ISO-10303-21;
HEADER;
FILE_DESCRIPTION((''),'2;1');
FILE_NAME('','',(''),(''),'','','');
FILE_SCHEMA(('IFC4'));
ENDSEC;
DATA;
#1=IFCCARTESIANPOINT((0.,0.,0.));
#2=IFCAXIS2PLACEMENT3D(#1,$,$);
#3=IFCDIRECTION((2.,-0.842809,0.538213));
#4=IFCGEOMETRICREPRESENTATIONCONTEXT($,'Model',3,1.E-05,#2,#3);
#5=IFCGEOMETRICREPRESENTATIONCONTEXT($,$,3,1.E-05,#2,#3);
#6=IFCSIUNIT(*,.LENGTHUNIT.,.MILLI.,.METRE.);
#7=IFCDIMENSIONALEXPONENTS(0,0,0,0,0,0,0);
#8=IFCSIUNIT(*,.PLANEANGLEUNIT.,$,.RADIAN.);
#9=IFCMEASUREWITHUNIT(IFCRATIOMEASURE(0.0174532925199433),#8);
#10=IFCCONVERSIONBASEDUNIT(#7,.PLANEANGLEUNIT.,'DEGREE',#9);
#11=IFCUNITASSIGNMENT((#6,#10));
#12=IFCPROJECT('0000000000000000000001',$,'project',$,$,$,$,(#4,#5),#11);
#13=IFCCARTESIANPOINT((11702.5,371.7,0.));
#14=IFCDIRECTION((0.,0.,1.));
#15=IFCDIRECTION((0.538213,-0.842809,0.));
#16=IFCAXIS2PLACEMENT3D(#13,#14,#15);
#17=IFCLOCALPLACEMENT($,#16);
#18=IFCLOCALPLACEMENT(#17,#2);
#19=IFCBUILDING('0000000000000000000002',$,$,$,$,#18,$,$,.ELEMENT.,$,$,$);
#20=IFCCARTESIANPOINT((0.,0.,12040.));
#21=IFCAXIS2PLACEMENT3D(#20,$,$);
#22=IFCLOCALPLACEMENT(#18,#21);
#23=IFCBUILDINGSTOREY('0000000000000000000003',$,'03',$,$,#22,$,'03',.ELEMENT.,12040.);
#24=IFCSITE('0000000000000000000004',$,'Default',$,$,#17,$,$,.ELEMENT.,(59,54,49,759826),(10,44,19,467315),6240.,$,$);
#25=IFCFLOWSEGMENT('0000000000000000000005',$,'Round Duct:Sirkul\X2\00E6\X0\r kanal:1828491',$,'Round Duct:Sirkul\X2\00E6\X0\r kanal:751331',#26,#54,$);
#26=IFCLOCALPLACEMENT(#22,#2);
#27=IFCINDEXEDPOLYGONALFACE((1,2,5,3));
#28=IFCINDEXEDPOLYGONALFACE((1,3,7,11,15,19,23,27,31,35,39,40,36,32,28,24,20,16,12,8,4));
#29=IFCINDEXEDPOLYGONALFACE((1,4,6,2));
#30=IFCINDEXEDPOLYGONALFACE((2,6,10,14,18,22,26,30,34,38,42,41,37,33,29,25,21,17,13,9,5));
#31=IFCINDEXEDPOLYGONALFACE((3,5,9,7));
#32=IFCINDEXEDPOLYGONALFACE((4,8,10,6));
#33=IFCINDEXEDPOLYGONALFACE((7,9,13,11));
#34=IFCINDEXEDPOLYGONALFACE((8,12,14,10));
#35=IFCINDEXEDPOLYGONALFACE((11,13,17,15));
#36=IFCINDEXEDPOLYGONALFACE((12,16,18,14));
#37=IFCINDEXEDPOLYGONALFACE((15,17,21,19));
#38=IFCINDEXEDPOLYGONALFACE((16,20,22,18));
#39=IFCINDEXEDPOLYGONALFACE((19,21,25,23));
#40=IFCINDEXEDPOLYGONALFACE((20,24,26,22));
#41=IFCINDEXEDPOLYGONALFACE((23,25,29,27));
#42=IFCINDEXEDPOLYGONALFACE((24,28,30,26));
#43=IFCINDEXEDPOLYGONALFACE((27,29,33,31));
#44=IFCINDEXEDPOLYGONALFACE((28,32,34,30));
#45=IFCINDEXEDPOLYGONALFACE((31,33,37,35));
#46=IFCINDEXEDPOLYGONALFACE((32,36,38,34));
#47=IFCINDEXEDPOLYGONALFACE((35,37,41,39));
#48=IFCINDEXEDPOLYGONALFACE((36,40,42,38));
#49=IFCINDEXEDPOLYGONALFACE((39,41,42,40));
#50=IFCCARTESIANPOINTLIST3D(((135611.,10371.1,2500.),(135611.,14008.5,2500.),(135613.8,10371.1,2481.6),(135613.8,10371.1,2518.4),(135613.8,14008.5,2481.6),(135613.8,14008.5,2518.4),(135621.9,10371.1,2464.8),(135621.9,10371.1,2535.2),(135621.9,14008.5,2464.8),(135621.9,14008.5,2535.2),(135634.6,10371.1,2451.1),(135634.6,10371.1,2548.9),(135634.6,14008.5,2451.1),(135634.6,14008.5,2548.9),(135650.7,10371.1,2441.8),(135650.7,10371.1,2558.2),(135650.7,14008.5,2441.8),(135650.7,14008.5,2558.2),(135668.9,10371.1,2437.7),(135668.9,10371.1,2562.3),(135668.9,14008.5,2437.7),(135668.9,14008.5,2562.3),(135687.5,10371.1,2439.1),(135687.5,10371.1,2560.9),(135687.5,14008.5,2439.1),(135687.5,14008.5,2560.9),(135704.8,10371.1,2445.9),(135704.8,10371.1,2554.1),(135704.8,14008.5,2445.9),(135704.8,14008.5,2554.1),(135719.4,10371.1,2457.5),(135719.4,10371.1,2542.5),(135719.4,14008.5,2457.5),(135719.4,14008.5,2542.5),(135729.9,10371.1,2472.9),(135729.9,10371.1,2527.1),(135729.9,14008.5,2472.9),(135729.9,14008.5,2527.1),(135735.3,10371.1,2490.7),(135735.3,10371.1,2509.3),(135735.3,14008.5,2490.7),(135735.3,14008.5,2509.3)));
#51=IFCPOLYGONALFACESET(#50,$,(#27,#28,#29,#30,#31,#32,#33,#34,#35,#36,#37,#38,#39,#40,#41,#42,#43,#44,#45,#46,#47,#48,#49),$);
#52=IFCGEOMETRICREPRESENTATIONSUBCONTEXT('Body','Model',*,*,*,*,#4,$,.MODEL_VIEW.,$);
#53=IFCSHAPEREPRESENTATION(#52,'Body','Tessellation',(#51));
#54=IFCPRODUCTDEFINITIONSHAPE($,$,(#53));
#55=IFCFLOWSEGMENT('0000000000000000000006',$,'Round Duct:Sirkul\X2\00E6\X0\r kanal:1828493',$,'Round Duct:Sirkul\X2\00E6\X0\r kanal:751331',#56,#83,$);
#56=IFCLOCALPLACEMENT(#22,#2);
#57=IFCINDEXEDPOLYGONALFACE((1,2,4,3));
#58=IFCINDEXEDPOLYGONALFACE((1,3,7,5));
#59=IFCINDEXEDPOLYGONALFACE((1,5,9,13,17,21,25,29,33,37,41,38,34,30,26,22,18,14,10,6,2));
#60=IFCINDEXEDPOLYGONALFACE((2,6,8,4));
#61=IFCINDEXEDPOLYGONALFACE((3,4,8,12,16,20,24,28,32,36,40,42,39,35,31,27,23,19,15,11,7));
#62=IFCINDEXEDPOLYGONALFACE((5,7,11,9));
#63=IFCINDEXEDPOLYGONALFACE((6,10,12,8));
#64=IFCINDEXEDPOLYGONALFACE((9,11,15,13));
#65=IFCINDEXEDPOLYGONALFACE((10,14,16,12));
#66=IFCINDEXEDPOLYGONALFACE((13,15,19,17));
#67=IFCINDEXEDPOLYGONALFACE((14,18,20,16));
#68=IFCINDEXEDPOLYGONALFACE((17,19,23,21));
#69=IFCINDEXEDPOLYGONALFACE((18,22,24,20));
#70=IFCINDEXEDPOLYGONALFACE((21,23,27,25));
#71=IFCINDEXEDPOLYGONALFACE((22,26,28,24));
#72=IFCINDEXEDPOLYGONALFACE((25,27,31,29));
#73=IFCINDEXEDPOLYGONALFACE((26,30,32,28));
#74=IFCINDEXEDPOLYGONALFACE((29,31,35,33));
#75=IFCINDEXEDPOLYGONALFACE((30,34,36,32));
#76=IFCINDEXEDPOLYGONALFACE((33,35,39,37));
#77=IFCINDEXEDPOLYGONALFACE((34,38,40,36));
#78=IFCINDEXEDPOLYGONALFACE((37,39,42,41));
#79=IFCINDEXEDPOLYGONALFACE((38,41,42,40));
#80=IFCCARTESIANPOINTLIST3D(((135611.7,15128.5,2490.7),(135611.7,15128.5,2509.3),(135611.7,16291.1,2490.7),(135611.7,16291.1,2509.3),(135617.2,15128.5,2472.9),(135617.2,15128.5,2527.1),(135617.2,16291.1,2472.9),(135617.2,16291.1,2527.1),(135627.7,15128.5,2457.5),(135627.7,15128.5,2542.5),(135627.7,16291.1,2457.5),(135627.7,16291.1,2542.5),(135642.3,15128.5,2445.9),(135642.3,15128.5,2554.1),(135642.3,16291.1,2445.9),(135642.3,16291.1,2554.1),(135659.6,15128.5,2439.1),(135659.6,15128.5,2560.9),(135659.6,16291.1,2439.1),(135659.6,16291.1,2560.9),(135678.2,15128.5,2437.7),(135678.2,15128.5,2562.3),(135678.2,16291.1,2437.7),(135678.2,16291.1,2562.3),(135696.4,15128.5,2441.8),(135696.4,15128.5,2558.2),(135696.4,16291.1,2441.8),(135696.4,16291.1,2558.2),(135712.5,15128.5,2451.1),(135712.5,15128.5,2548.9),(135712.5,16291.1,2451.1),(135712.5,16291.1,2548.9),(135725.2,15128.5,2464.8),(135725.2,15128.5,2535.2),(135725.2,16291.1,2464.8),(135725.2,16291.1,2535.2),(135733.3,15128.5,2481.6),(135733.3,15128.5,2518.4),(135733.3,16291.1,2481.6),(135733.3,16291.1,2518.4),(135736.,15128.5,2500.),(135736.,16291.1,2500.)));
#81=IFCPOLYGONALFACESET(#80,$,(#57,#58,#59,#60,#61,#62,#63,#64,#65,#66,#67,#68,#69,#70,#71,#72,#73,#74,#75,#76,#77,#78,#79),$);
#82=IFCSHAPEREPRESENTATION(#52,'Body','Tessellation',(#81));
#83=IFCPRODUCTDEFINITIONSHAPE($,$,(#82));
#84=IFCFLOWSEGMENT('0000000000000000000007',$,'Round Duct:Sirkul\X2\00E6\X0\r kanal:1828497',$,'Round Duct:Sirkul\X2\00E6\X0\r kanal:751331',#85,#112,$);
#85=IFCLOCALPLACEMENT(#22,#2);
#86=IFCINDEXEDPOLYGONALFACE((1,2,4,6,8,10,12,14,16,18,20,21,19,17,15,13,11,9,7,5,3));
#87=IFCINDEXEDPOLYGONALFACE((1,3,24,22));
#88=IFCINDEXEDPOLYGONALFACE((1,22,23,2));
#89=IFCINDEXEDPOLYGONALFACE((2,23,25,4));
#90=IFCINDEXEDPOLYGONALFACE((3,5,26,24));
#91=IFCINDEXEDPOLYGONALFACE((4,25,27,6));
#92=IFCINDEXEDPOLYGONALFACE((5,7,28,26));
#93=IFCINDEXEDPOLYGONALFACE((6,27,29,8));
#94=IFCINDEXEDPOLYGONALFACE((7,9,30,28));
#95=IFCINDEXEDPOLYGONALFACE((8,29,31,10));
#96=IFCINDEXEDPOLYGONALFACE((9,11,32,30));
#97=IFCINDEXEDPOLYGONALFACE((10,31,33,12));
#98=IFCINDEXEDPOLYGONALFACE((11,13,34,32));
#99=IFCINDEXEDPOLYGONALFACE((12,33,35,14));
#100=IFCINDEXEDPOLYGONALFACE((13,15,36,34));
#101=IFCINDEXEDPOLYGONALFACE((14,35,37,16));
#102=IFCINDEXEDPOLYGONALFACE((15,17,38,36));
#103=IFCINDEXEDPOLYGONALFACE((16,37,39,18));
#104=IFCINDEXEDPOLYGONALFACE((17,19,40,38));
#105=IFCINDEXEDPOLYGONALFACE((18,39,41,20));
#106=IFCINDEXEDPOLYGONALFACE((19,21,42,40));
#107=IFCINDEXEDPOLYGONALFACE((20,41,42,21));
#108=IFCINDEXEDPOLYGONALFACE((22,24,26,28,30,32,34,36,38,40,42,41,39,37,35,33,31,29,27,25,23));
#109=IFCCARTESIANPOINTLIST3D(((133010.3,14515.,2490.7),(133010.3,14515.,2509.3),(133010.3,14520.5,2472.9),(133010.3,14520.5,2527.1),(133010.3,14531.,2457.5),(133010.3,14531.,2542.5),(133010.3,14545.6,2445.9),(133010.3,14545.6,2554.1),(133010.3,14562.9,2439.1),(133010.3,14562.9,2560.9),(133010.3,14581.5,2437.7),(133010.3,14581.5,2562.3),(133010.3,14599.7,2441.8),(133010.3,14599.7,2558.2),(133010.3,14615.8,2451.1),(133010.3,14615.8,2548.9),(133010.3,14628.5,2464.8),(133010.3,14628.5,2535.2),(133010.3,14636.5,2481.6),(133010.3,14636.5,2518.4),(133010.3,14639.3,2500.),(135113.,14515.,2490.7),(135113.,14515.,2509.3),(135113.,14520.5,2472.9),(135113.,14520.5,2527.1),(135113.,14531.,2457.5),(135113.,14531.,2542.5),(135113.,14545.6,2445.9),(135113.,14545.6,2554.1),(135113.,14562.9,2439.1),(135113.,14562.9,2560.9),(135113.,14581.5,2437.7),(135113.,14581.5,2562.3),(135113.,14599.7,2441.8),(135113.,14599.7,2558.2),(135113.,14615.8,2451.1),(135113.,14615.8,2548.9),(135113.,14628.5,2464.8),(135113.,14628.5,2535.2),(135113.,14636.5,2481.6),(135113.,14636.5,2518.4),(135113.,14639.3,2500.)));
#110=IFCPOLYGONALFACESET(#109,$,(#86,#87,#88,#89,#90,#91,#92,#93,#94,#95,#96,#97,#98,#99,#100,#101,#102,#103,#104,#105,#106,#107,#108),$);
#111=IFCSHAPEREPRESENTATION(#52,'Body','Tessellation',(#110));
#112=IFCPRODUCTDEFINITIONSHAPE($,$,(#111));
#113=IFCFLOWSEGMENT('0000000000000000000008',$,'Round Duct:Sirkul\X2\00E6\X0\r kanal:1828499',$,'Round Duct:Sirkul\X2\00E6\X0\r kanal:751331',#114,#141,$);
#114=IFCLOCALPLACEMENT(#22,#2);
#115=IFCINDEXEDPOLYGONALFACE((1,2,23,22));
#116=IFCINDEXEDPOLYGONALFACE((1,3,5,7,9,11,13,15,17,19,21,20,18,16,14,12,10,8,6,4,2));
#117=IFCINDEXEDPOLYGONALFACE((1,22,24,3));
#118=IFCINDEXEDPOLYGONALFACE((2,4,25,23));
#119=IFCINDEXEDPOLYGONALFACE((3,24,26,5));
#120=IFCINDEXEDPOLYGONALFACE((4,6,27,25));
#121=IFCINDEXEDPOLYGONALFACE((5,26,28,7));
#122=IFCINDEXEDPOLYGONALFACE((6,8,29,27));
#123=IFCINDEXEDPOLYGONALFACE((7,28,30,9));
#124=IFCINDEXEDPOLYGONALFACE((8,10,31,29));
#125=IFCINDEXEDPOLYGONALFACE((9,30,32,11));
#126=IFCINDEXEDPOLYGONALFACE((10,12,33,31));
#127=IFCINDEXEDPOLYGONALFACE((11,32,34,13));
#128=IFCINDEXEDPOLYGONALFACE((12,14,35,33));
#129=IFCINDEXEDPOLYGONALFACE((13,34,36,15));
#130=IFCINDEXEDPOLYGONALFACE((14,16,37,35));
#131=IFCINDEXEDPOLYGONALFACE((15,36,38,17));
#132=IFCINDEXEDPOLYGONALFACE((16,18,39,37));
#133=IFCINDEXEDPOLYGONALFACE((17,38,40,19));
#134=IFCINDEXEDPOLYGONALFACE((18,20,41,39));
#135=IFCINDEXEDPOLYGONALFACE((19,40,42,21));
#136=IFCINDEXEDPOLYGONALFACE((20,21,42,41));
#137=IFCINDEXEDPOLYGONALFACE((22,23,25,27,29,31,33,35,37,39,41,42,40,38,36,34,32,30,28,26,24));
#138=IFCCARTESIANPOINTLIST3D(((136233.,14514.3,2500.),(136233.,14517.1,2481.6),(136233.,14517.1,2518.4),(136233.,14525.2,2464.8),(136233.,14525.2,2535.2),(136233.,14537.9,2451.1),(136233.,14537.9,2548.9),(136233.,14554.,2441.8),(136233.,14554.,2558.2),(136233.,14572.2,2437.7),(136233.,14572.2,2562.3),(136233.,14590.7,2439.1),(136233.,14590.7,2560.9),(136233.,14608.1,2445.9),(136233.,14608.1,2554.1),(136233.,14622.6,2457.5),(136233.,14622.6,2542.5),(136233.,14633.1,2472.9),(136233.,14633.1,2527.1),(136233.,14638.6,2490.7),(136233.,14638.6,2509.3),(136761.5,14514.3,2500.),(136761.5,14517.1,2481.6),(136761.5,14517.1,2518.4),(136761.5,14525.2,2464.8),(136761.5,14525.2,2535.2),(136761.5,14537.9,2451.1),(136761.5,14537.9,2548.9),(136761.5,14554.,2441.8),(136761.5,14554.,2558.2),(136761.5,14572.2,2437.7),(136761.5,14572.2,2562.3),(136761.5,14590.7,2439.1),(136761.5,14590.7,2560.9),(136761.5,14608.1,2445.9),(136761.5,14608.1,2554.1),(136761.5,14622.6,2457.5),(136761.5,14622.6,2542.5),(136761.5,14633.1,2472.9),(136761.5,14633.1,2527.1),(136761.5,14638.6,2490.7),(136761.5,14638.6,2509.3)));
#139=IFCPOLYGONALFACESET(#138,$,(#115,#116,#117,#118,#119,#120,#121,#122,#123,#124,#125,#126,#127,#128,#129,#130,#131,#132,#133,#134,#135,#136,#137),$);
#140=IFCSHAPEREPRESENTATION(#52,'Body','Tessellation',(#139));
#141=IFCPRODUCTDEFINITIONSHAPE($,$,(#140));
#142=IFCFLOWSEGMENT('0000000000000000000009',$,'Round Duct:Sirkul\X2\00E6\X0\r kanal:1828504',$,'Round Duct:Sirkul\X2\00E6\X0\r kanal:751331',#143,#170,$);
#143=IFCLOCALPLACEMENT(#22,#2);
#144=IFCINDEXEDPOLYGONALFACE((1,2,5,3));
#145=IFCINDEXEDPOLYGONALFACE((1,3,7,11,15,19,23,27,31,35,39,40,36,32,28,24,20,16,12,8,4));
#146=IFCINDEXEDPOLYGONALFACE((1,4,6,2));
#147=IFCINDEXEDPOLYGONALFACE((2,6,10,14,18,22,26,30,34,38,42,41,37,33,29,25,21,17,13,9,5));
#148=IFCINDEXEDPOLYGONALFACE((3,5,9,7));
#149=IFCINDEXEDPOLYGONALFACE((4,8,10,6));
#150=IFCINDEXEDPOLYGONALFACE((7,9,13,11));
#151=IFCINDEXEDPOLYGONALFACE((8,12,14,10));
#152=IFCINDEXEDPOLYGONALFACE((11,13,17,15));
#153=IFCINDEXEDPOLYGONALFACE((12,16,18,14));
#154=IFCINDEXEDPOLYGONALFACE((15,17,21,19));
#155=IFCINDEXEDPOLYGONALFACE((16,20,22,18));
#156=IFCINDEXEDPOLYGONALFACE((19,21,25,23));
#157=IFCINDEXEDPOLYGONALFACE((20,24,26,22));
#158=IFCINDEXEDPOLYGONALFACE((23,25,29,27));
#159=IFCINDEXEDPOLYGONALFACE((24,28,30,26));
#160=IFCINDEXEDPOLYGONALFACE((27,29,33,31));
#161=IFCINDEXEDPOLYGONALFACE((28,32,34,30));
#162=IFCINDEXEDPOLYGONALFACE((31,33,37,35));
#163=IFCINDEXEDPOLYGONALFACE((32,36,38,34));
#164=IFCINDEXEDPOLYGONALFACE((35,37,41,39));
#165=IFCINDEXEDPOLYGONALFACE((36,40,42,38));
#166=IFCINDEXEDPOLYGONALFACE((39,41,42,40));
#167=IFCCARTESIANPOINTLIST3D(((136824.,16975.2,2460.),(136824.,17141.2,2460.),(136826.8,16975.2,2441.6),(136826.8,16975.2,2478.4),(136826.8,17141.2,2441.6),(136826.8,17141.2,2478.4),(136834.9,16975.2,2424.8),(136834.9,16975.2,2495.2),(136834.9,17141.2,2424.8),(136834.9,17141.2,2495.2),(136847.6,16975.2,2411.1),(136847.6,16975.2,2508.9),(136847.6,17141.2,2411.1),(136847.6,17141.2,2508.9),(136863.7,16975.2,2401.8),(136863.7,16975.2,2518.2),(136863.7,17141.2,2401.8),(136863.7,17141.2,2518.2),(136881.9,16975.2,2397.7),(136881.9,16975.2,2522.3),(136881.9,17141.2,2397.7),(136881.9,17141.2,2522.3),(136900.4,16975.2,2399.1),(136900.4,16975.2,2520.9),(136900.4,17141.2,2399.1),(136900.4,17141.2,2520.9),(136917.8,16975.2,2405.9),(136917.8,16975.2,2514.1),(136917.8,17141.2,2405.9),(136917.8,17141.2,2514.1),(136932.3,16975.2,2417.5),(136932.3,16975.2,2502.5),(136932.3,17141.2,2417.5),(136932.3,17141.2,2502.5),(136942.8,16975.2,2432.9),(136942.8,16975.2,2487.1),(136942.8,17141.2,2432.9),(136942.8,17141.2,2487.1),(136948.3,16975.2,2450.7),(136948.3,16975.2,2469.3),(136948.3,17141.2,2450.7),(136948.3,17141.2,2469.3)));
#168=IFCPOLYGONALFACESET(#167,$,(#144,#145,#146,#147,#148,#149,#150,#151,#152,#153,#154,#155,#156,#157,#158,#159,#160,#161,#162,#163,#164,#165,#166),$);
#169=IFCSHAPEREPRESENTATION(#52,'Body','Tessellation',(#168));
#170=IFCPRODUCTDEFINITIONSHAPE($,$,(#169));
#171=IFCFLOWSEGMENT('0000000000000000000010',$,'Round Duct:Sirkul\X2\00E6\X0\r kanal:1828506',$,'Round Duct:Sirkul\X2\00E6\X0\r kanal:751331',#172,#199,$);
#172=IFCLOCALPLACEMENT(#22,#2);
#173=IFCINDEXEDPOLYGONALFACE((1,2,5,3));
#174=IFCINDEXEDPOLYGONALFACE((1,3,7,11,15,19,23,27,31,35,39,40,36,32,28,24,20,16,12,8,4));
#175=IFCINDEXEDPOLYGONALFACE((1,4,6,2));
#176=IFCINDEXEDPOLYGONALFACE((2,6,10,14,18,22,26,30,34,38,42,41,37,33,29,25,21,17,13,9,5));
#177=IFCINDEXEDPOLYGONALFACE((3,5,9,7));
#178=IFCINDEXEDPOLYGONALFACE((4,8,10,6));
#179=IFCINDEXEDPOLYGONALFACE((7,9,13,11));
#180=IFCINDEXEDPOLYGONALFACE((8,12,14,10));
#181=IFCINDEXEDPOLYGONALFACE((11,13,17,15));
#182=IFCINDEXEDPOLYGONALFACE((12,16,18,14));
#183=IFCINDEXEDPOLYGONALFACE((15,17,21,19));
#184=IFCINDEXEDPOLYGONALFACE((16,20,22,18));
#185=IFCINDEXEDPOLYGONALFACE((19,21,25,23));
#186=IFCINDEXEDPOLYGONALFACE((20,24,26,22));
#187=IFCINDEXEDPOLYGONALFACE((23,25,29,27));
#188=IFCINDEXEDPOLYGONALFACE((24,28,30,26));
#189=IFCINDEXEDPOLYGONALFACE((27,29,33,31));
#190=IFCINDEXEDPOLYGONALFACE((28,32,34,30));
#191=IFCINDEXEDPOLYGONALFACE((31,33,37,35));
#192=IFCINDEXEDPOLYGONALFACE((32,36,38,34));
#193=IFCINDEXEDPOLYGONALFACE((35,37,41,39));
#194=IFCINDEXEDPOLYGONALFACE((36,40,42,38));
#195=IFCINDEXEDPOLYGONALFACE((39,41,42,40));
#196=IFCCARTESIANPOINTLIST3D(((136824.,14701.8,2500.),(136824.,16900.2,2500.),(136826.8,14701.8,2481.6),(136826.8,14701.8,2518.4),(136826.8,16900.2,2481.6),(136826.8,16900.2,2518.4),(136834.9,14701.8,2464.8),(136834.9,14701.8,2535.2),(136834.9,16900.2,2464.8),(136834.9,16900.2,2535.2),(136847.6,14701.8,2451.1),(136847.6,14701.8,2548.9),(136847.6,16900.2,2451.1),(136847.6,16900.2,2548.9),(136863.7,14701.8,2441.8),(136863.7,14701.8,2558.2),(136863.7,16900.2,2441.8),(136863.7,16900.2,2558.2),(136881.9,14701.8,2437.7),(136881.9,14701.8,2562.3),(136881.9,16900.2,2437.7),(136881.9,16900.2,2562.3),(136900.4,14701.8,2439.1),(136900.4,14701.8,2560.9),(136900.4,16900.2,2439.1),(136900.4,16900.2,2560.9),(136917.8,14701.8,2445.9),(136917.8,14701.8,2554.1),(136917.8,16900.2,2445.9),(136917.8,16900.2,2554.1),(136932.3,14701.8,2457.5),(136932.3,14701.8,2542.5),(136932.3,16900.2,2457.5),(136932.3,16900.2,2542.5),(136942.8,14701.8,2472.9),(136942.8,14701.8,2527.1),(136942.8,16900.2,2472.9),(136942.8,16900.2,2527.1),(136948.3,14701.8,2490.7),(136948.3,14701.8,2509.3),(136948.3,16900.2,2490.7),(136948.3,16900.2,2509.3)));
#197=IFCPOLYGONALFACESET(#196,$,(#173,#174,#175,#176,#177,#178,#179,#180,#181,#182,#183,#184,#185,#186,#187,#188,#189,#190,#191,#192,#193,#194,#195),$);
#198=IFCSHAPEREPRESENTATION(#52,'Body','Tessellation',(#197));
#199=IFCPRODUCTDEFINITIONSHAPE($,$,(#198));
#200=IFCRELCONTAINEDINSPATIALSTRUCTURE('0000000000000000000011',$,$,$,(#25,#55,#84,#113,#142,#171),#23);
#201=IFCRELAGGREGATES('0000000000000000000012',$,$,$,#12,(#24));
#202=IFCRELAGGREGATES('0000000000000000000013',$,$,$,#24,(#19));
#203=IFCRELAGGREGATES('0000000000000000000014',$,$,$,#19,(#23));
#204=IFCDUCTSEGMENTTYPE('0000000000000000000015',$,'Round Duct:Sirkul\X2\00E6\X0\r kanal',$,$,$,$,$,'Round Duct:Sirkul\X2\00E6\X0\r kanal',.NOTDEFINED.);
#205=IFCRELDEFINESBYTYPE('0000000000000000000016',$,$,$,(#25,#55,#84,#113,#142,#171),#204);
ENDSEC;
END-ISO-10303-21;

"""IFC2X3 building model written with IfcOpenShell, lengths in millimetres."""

from ifc_helpers import new_model, entity, si_unit, converted_unit, direction, frame, frame_2d, origin, origin_2d_with_axis, place, context, subcontext, project, spatial, circle, extrude, type_object, element, save


model = new_model("IFC2X3")

# Units and contexts
model_context = context("Model", 3, precision=1e-05, world=origin(), true_north=direction((2.0, -0.842809, 0.538213)))
context_of_model = context(None, 3, precision=1e-05, world=origin(), true_north=direction((2.0, -0.842809, 0.538213)))
body_context = subcontext(model_context, "Body", "Model", "MODEL_VIEW")
ifc_project = project(units=[si_unit("LENGTHUNIT", "METRE", prefix="MILLI"), converted_unit("PLANEANGLEUNIT", "DEGREE", entity("IfcRatioMeasure", 0.0174532925199433), si_unit("PLANEANGLEUNIT", "RADIAN"), dimensions=[0, 0, 0, 0, 0, 0, 0])], contexts=[model_context, context_of_model])

# Site, building, storey
site_placement = place(None, frame((11702.5, 371.7, 0.0), z_axis=(0.0, 0.0, 1.0), x_axis=(0.538213, -0.842809, 0.0)))
site = spatial("IfcSite", under=ifc_project, at=site_placement, Name="Default", CompositionType="ELEMENT", RefLatitude=(59, 54, 49, 759826), RefLongitude=(10, 44, 19, 467315), RefElevation=6240.0)
building_placement = place(site_placement, origin())
building = spatial("IfcBuilding", under=site, at=building_placement, CompositionType="ELEMENT")
storey_placement = place(building_placement, frame((0.0, 0.0, 12040.0)))
storey = spatial("IfcBuildingStorey", under=building, at=storey_placement, Name="03", LongName="03", CompositionType="ELEMENT", Elevation=12040.0)

# Flow segments
duct_segment_type_1 = type_object("IfcDuctSegmentType", Name="Round Duct:Sirkulær kanal", ElementType="Round Duct:Sirkulær kanal", PredefinedType="NOTDEFINED")
flow_segment_1_placement = place(storey_placement, origin())
element("IfcFlowSegment", 1, at=flow_segment_1_placement, inside=storey, type_object=duct_segment_type_1, Name="Round Duct:Sirkulær kanal:1828491", ObjectType="Round Duct:Sirkulær kanal:751331", context=body_context, shape_type="SweptSolid", body=[
    extrude(circle(Radius=62.5, at=frame_2d((0.0, 0.0), x_axis=(1.0, 0.0))), frame((135673.5, 10371.1, 2500.0), z_axis=(0.0, 1.0, 0.0), x_axis=(-1.0, 0.0, 0.0)), (0.0, 0.0, 1.0), 3637.4),
])
flow_segment_2_placement = place(storey_placement, origin())
element("IfcFlowSegment", 2, at=flow_segment_2_placement, inside=storey, type_object=duct_segment_type_1, Name="Round Duct:Sirkulær kanal:1828493", ObjectType="Round Duct:Sirkulær kanal:751331", context=body_context, shape_type="SweptSolid", body=[
    extrude(circle(Radius=62.5, at=origin_2d_with_axis()), frame((135673.5, 15128.5, 2500.0), z_axis=(0.0, 1.0, 0.0), x_axis=(1.0, 0.0, 0.0)), (0.0, 0.0, 1.0), 1162.6),
])
flow_segment_3_placement = place(storey_placement, origin())
element("IfcFlowSegment", 3, at=flow_segment_3_placement, inside=storey, type_object=duct_segment_type_1, Name="Round Duct:Sirkulær kanal:1828497", ObjectType="Round Duct:Sirkulær kanal:751331", context=body_context, shape_type="SweptSolid", body=[
    extrude(circle(Radius=62.5, at=frame_2d((0.0, 0.0), x_axis=(1.0, 0.0))), frame((133010.3, 14576.8, 2500.0), z_axis=(1.0, 0.0, 0.0), x_axis=(0.0, 1.0, 0.0)), (0.0, 0.0, 1.0), 2102.7),
])
flow_segment_4_placement = place(storey_placement, origin())
element("IfcFlowSegment", 4, at=flow_segment_4_placement, inside=storey, type_object=duct_segment_type_1, Name="Round Duct:Sirkulær kanal:1828499", ObjectType="Round Duct:Sirkulær kanal:751331", context=body_context, shape_type="SweptSolid", body=[
    extrude(circle(Radius=62.5, at=origin_2d_with_axis()), frame((136233.0, 14576.8, 2500.0), z_axis=(1.0, 0.0, 0.0), x_axis=(0.0, -1.0, 0.0)), (0.0, 0.0, 1.0), 528.5),
])
flow_segment_5_placement = place(storey_placement, origin())
element("IfcFlowSegment", 5, at=flow_segment_5_placement, inside=storey, type_object=duct_segment_type_1, Name="Round Duct:Sirkulær kanal:1828504", ObjectType="Round Duct:Sirkulær kanal:751331", context=body_context, shape_type="SweptSolid", body=[
    extrude(circle(Radius=62.5, at=origin_2d_with_axis()), frame((136886.5, 16975.2, 2460.0), z_axis=(0.000011, 1.0, 0.0), x_axis=(-1.0, 0.000011, 0.0)), (0.0, 0.0, 1.0), 166.0),
])
flow_segment_6_placement = place(storey_placement, origin())
element("IfcFlowSegment", 6, at=flow_segment_6_placement, inside=storey, type_object=duct_segment_type_1, Name="Round Duct:Sirkulær kanal:1828506", ObjectType="Round Duct:Sirkulær kanal:751331", context=body_context, shape_type="SweptSolid", body=[
    extrude(circle(Radius=62.5, at=origin_2d_with_axis()), frame((136886.5, 14701.8, 2500.0), z_axis=(0.0, 1.0, 0.0), x_axis=(-1.0, 0.0, 0.0)), (0.0, 0.0, 1.0), 2198.4),
])

save(model, "model.ifc")
